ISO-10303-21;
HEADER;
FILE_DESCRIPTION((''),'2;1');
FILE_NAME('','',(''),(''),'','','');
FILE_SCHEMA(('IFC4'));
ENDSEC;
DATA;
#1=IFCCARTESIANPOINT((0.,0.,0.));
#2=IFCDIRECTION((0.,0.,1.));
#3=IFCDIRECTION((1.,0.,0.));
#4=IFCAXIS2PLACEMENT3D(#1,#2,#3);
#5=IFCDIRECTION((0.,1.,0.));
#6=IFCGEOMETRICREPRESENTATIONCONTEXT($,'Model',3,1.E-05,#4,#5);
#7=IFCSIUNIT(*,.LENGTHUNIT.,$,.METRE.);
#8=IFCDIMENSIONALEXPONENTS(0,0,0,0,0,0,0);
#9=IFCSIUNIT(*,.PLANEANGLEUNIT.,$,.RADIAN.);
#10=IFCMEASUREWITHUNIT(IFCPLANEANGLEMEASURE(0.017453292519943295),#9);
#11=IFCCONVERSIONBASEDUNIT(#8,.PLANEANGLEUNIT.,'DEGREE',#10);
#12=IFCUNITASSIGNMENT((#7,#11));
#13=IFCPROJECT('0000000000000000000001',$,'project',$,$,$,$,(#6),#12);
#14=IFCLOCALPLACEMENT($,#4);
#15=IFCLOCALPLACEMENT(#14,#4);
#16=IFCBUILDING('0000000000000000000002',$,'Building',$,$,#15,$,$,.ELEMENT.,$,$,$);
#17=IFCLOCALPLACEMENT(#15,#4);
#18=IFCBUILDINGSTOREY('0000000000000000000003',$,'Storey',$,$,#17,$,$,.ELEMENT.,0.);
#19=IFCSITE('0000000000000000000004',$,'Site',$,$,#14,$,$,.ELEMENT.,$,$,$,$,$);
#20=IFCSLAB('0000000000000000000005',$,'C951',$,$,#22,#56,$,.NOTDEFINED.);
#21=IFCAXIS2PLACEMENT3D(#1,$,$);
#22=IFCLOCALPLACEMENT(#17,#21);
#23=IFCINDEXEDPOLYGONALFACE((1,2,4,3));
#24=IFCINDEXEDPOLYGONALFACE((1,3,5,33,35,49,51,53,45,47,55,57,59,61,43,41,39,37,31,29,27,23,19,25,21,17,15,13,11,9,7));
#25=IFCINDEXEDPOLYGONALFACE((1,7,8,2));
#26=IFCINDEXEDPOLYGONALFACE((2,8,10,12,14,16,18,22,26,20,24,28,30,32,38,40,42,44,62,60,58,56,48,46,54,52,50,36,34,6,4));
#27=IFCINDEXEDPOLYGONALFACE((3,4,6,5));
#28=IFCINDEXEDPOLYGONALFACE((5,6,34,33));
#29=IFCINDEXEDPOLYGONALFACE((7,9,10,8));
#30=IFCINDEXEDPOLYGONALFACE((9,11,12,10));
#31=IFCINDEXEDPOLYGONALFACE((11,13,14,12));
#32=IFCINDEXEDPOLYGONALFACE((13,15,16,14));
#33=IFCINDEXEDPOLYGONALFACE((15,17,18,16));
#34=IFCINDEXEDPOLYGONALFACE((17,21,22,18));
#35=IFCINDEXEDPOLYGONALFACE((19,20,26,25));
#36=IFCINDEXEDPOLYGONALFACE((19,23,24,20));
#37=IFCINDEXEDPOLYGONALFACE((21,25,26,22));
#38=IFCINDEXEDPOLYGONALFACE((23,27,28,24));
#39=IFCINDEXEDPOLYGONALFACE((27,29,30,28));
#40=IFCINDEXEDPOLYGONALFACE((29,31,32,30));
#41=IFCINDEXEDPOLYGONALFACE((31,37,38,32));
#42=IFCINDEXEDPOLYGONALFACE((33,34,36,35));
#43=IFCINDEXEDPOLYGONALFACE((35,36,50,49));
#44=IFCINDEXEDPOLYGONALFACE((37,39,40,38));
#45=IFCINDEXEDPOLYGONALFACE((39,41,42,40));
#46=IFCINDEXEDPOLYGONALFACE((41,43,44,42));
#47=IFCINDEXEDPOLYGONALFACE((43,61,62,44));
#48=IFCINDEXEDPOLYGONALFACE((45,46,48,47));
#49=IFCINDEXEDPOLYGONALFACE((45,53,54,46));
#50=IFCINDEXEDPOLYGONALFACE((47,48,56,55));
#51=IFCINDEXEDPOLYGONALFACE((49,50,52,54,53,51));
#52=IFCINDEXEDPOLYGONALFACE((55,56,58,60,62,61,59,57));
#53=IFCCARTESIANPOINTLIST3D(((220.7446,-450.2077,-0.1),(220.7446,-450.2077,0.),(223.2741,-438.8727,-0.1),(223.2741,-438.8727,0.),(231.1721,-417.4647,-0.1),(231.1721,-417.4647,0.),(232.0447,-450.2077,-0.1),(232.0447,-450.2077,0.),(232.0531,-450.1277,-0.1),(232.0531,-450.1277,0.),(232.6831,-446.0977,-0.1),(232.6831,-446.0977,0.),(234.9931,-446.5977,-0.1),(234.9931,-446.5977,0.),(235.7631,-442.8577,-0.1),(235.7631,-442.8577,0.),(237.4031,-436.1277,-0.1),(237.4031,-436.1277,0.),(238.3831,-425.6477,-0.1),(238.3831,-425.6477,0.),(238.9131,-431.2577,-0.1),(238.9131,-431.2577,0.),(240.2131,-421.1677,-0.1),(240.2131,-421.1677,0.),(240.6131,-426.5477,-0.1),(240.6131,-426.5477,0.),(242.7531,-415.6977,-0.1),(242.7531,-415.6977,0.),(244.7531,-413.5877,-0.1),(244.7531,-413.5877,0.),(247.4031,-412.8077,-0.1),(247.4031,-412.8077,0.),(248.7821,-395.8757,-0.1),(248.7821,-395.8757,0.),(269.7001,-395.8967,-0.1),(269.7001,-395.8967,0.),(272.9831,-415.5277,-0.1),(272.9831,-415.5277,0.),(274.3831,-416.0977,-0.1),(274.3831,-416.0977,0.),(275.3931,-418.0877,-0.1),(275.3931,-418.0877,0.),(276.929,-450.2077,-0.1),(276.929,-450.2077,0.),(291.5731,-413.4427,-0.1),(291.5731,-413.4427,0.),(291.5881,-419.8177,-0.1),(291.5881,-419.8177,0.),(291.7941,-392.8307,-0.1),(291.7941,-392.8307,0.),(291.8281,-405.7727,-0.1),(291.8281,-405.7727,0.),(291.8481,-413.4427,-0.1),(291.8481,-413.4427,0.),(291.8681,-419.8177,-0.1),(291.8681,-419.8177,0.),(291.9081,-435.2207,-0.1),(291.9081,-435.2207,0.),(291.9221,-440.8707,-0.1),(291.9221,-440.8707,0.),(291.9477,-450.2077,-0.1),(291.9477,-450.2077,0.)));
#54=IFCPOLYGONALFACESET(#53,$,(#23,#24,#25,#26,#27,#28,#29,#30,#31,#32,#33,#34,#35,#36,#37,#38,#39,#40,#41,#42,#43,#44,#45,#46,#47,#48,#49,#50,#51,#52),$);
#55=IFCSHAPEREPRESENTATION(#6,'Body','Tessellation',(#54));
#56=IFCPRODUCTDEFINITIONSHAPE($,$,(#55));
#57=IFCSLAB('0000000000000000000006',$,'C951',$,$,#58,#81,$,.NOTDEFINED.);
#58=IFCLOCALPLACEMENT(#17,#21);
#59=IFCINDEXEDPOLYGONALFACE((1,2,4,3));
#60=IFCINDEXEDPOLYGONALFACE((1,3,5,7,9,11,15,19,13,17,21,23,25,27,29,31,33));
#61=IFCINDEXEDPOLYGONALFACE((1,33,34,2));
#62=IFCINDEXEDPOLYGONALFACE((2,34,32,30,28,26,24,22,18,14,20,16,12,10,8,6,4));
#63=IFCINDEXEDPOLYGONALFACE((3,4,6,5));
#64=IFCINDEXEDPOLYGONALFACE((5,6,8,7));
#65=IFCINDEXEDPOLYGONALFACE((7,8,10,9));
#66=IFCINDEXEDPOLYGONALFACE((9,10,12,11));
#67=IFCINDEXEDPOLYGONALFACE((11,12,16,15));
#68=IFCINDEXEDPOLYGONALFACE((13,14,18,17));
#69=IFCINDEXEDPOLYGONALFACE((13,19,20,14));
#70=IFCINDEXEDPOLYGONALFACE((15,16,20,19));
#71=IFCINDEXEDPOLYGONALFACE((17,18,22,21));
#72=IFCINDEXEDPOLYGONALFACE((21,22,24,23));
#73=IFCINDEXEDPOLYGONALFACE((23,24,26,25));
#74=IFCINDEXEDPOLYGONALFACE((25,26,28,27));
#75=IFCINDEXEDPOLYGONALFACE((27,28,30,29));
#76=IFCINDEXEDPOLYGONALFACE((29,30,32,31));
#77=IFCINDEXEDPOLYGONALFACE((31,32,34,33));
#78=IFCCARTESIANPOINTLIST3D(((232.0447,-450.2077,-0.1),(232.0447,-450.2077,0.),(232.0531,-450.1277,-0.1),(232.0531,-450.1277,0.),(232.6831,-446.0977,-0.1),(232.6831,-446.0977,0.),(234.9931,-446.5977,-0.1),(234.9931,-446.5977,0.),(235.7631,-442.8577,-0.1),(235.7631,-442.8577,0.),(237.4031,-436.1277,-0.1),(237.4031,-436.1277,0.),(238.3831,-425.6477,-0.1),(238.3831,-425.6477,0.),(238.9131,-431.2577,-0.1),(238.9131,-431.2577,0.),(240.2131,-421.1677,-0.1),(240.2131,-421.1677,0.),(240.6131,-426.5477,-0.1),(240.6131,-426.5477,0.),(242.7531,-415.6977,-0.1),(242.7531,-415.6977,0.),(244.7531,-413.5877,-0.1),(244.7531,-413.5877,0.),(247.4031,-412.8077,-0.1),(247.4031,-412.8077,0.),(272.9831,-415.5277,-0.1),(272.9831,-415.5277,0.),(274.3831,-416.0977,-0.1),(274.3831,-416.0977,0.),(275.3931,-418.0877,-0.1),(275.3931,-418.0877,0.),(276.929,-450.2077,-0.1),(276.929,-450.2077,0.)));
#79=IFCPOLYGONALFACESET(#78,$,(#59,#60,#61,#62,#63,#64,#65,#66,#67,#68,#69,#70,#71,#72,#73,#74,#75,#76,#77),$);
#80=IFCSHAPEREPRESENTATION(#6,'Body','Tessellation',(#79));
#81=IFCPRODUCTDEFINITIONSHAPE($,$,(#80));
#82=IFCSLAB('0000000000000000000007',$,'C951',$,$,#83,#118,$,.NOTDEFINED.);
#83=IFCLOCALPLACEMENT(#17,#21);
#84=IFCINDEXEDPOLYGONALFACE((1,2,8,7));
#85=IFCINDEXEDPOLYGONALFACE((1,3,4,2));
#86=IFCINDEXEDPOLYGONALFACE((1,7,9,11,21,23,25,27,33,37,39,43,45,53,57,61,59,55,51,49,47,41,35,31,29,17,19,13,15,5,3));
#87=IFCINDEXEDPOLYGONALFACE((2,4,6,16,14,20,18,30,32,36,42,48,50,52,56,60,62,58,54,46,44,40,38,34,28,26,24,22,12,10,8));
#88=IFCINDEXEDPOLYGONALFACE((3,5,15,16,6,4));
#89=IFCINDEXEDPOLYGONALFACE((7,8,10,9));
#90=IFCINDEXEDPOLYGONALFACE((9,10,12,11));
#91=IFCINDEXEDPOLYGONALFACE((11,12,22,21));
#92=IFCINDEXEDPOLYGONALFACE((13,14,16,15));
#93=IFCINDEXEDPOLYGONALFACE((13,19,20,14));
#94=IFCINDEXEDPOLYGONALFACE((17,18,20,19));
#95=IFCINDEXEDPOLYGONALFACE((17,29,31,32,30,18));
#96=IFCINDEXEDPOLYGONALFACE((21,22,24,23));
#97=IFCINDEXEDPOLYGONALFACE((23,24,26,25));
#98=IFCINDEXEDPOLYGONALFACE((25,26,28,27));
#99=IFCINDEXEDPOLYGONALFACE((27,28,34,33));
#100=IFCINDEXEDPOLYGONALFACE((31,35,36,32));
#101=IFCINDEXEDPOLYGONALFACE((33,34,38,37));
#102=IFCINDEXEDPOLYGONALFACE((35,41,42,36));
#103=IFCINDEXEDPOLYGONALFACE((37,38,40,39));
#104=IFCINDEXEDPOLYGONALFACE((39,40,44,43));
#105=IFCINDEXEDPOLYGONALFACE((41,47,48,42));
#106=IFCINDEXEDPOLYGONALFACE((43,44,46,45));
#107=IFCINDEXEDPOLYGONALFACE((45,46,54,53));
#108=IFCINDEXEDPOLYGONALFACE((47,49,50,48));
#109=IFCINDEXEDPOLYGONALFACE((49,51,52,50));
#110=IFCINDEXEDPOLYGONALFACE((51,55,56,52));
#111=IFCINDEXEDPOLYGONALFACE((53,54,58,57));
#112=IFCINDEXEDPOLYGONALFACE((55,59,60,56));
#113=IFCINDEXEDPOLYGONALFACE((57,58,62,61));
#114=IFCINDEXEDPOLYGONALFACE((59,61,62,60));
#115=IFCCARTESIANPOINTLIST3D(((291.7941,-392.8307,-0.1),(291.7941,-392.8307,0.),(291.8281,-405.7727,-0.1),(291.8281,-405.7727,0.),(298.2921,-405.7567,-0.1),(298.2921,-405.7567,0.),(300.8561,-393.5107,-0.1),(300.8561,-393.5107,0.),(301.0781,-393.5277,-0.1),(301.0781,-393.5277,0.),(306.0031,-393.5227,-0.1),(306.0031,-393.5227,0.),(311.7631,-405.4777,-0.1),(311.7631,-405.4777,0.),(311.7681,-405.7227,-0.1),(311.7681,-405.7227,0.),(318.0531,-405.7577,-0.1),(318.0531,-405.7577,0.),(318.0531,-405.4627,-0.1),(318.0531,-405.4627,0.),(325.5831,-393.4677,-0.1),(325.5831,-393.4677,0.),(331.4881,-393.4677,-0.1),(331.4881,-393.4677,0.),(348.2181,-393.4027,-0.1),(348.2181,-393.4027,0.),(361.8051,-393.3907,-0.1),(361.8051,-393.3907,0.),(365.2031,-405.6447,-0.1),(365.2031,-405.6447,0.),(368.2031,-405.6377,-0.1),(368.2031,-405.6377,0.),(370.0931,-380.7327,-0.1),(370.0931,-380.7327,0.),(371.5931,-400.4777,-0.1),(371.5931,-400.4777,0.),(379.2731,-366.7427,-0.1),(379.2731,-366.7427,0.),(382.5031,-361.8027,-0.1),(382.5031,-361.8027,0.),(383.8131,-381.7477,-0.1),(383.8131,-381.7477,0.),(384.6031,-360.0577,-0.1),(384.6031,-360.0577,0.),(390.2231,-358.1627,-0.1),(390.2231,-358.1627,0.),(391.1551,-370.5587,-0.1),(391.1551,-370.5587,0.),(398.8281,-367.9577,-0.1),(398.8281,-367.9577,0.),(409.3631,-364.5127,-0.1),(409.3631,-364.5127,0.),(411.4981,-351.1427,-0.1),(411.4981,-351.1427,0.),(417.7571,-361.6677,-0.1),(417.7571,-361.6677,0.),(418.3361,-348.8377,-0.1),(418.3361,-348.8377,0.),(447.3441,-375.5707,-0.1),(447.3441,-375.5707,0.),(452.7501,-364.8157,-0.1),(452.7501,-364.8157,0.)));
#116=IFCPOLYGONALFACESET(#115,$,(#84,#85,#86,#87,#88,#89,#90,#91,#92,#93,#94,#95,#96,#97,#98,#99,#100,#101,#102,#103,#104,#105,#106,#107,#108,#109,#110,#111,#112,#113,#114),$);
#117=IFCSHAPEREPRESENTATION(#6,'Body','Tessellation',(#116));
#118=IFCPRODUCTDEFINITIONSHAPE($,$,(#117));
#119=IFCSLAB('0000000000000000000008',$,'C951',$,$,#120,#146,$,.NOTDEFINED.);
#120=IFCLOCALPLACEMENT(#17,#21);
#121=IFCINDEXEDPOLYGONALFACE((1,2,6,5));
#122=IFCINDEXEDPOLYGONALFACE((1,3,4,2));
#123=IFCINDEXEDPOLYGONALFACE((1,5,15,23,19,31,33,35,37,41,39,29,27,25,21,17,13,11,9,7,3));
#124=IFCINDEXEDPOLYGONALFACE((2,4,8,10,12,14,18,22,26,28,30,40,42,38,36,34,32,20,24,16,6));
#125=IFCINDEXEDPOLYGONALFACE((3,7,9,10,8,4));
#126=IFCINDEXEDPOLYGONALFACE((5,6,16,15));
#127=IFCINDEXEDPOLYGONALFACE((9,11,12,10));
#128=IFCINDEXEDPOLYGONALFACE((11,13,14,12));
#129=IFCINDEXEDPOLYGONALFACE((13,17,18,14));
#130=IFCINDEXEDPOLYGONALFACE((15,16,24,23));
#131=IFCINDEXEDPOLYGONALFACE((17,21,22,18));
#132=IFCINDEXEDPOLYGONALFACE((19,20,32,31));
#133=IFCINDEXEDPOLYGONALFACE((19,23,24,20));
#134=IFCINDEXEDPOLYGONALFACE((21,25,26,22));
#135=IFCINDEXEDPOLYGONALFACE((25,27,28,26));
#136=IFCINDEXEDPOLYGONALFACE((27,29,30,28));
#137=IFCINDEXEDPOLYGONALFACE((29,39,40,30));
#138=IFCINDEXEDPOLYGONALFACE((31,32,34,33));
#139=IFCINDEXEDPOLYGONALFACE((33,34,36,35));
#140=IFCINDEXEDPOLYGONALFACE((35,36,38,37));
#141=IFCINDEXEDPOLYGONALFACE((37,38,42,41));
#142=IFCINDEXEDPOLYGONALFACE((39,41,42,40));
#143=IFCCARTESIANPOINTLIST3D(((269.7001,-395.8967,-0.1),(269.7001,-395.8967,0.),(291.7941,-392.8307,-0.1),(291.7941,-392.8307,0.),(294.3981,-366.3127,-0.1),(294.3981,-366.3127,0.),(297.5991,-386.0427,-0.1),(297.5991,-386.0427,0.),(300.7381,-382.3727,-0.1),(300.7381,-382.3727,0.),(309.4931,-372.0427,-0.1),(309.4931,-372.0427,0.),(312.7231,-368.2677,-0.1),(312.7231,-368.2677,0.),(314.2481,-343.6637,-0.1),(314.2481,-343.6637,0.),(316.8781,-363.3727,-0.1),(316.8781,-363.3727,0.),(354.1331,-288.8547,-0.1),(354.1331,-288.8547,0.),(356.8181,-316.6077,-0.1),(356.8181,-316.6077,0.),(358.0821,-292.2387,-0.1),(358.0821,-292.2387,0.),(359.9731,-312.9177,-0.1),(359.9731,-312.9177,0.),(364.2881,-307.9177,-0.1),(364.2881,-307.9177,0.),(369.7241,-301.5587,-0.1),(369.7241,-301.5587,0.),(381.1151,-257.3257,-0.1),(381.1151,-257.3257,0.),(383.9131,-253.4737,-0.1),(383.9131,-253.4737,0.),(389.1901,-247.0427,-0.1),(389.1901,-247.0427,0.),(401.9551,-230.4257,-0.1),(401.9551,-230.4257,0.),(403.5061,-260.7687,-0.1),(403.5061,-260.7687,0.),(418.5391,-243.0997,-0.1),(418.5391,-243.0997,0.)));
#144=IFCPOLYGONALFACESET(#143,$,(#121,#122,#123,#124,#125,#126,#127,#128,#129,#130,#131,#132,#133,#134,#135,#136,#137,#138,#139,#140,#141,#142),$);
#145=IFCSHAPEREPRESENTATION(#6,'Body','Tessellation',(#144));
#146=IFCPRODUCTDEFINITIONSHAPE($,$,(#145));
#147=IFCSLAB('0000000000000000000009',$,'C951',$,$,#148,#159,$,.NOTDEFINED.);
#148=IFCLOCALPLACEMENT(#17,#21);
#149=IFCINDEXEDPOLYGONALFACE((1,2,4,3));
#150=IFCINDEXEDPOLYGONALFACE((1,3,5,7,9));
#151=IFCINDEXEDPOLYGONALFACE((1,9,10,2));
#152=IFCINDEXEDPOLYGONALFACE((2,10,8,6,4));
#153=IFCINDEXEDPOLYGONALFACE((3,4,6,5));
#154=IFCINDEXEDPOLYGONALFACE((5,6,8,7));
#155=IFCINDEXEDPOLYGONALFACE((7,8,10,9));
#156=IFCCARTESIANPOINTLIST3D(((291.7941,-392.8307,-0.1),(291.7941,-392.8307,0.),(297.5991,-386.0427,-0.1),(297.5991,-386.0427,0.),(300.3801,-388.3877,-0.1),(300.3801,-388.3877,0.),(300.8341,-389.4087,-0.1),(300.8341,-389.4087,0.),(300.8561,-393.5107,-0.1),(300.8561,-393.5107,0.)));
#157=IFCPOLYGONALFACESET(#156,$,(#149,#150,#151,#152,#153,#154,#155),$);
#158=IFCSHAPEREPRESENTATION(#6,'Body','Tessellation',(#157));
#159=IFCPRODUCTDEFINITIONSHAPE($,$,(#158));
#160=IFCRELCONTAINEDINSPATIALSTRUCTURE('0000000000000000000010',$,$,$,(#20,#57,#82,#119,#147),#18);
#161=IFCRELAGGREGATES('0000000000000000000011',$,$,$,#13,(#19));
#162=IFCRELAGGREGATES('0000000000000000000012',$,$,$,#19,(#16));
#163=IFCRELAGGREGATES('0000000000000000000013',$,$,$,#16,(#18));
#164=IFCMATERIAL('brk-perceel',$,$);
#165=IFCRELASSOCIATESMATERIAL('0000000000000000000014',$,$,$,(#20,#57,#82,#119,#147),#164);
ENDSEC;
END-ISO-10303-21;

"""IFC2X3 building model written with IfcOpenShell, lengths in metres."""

from ifc_helpers import new_model, entity, si_unit, converted_unit, direction, frame, origin_with_axes, place, context, project, spatial, polyline, outline, extrude, material, element, save


model = new_model("IFC2X3")

# Units and contexts
model_context = context("Model", 3, precision=1e-05, world=origin_with_axes(), true_north=direction((0.0, 1.0, 0.0)))
ifc_project = project(units=[si_unit("LENGTHUNIT", "METRE"), converted_unit("PLANEANGLEUNIT", "DEGREE", entity("IfcPlaneAngleMeasure", 0.017453292519943295), si_unit("PLANEANGLEUNIT", "RADIAN"), dimensions=[0, 0, 0, 0, 0, 0, 0])], contexts=[model_context])

# Site, building, storey
site_placement = place(None, origin_with_axes())
site = spatial("IfcSite", under=ifc_project, at=site_placement, Name="Site", CompositionType="ELEMENT")
building_placement = place(site_placement, origin_with_axes())
building = spatial("IfcBuilding", under=site, at=building_placement, Name="Building", CompositionType="ELEMENT")
storey_placement = place(building_placement, origin_with_axes())
storey = spatial("IfcBuildingStorey", under=building, at=storey_placement, Name="Storey", CompositionType="ELEMENT", Elevation=0.0)

# Slabs
ifc_material = material(Name="brk-perceel")
slab_1_placement = place(storey_placement, frame((0.0, 0.0, -0.1), z_axis=(0.0, 0.0, 1.0), x_axis=(1.0, 0.0, 0.0)))
element("IfcSlab", 1, at=slab_1_placement, inside=storey, material=ifc_material, Name="C951", PredefinedType="NOTDEFINED", context=model_context, shape_type="SweptSolid", body=[
    extrude(outline(polyline([(223.2741, -438.8727), (231.1721, -417.4647), (248.7821, -395.8757), (269.7001, -395.8967), (291.7941, -392.8307), (291.8281, -405.7727), (291.8481, -413.4427), (291.5731, -413.4427), (291.5881, -419.8177), (291.8681, -419.8177), (291.9081, -435.2207), (291.9221, -440.8707), (291.9477, -450.2077), (276.929, -450.2077), (275.3931, -418.0877), (274.3831, -416.0977), (272.9831, -415.5277), (247.4031, -412.8077), (244.7531, -413.5877), (242.7531, -415.6977), (240.2131, -421.1677), (238.3831, -425.6477), (240.6131, -426.5477), (238.9131, -431.2577), (237.4031, -436.1277), (235.7631, -442.8577), (234.9931, -446.5977), (232.6831, -446.0977), (232.0531, -450.1277), (232.0447, -450.2077), (220.7446, -450.2077), (223.2741, -438.8727)])), origin_with_axes(), (0.0, 0.0, 1.0), 0.1),
])
slab_2_placement = place(storey_placement, frame((0.0, 0.0, -0.1), z_axis=(0.0, 0.0, 1.0), x_axis=(1.0, 0.0, 0.0)))
element("IfcSlab", 2, at=slab_2_placement, inside=storey, material=ifc_material, Name="C951", PredefinedType="NOTDEFINED", context=model_context, shape_type="SweptSolid", body=[
    extrude(outline(polyline([(232.0531, -450.1277), (232.6831, -446.0977), (234.9931, -446.5977), (235.7631, -442.8577), (237.4031, -436.1277), (238.9131, -431.2577), (240.6131, -426.5477), (238.3831, -425.6477), (240.2131, -421.1677), (242.7531, -415.6977), (244.7531, -413.5877), (247.4031, -412.8077), (272.9831, -415.5277), (274.3831, -416.0977), (275.3931, -418.0877), (276.929, -450.2077), (232.0447, -450.2077), (232.0531, -450.1277)])), origin_with_axes(), (0.0, 0.0, 1.0), 0.1),
])
slab_3_placement = place(storey_placement, frame((0.0, 0.0, -0.1), z_axis=(0.0, 0.0, 1.0), x_axis=(1.0, 0.0, 0.0)))
element("IfcSlab", 3, at=slab_3_placement, inside=storey, material=ifc_material, Name="C951", PredefinedType="NOTDEFINED", context=model_context, shape_type="SweptSolid", body=[
    extrude(outline(polyline([(300.8561, -393.5107), (301.0781, -393.5277), (306.0031, -393.5227), (325.5831, -393.4677), (331.4881, -393.4677), (348.2181, -393.4027), (361.8051, -393.3907), (370.0931, -380.7327), (379.2731, -366.7427), (382.5031, -361.8027), (384.6031, -360.0577), (390.2231, -358.1627), (411.4981, -351.1427), (418.3361, -348.8377), (452.7501, -364.8157), (447.3441, -375.5707), (417.7571, -361.6677), (409.3631, -364.5127), (398.8281, -367.9577), (391.1551, -370.5587), (383.8131, -381.7477), (371.5931, -400.4777), (368.2031, -405.6377), (365.2031, -405.6447), (318.0531, -405.7577), (318.0531, -405.4627), (311.7631, -405.4777), (311.7681, -405.7227), (298.2921, -405.7567), (291.8281, -405.7727), (291.7941, -392.8307), (300.8561, -393.5107)])), origin_with_axes(), (0.0, 0.0, 1.0), 0.1),
])
slab_4_placement = place(storey_placement, frame((0.0, 0.0, -0.1), z_axis=(0.0, 0.0, 1.0), x_axis=(1.0, 0.0, 0.0)))
element("IfcSlab", 4, at=slab_4_placement, inside=storey, material=ifc_material, Name="C951", PredefinedType="NOTDEFINED", context=model_context, shape_type="SweptSolid", body=[
    extrude(outline(polyline([(294.3981, -366.3127), (314.2481, -343.6637), (358.0821, -292.2387), (354.1331, -288.8547), (381.1151, -257.3257), (383.9131, -253.4737), (389.1901, -247.0427), (401.9551, -230.4257), (418.5391, -243.0997), (403.5061, -260.7687), (369.7241, -301.5587), (364.2881, -307.9177), (359.9731, -312.9177), (356.8181, -316.6077), (316.8781, -363.3727), (312.7231, -368.2677), (309.4931, -372.0427), (300.7381, -382.3727), (297.5991, -386.0427), (291.7941, -392.8307), (269.7001, -395.8967), (294.3981, -366.3127)])), origin_with_axes(), (0.0, 0.0, 1.0), 0.1),
])
slab_5_placement = place(storey_placement, frame((0.0, 0.0, -0.1), z_axis=(0.0, 0.0, 1.0), x_axis=(1.0, 0.0, 0.0)))
element("IfcSlab", 5, at=slab_5_placement, inside=storey, material=ifc_material, Name="C951", PredefinedType="NOTDEFINED", context=model_context, shape_type="SweptSolid", body=[
    extrude(outline(polyline([(300.3801, -388.3877), (300.8341, -389.4087), (300.8561, -393.5107), (291.7941, -392.8307), (297.5991, -386.0427), (300.3801, -388.3877)])), origin_with_axes(), (0.0, 0.0, 1.0), 0.1),
])

save(model, "model.ifc")
